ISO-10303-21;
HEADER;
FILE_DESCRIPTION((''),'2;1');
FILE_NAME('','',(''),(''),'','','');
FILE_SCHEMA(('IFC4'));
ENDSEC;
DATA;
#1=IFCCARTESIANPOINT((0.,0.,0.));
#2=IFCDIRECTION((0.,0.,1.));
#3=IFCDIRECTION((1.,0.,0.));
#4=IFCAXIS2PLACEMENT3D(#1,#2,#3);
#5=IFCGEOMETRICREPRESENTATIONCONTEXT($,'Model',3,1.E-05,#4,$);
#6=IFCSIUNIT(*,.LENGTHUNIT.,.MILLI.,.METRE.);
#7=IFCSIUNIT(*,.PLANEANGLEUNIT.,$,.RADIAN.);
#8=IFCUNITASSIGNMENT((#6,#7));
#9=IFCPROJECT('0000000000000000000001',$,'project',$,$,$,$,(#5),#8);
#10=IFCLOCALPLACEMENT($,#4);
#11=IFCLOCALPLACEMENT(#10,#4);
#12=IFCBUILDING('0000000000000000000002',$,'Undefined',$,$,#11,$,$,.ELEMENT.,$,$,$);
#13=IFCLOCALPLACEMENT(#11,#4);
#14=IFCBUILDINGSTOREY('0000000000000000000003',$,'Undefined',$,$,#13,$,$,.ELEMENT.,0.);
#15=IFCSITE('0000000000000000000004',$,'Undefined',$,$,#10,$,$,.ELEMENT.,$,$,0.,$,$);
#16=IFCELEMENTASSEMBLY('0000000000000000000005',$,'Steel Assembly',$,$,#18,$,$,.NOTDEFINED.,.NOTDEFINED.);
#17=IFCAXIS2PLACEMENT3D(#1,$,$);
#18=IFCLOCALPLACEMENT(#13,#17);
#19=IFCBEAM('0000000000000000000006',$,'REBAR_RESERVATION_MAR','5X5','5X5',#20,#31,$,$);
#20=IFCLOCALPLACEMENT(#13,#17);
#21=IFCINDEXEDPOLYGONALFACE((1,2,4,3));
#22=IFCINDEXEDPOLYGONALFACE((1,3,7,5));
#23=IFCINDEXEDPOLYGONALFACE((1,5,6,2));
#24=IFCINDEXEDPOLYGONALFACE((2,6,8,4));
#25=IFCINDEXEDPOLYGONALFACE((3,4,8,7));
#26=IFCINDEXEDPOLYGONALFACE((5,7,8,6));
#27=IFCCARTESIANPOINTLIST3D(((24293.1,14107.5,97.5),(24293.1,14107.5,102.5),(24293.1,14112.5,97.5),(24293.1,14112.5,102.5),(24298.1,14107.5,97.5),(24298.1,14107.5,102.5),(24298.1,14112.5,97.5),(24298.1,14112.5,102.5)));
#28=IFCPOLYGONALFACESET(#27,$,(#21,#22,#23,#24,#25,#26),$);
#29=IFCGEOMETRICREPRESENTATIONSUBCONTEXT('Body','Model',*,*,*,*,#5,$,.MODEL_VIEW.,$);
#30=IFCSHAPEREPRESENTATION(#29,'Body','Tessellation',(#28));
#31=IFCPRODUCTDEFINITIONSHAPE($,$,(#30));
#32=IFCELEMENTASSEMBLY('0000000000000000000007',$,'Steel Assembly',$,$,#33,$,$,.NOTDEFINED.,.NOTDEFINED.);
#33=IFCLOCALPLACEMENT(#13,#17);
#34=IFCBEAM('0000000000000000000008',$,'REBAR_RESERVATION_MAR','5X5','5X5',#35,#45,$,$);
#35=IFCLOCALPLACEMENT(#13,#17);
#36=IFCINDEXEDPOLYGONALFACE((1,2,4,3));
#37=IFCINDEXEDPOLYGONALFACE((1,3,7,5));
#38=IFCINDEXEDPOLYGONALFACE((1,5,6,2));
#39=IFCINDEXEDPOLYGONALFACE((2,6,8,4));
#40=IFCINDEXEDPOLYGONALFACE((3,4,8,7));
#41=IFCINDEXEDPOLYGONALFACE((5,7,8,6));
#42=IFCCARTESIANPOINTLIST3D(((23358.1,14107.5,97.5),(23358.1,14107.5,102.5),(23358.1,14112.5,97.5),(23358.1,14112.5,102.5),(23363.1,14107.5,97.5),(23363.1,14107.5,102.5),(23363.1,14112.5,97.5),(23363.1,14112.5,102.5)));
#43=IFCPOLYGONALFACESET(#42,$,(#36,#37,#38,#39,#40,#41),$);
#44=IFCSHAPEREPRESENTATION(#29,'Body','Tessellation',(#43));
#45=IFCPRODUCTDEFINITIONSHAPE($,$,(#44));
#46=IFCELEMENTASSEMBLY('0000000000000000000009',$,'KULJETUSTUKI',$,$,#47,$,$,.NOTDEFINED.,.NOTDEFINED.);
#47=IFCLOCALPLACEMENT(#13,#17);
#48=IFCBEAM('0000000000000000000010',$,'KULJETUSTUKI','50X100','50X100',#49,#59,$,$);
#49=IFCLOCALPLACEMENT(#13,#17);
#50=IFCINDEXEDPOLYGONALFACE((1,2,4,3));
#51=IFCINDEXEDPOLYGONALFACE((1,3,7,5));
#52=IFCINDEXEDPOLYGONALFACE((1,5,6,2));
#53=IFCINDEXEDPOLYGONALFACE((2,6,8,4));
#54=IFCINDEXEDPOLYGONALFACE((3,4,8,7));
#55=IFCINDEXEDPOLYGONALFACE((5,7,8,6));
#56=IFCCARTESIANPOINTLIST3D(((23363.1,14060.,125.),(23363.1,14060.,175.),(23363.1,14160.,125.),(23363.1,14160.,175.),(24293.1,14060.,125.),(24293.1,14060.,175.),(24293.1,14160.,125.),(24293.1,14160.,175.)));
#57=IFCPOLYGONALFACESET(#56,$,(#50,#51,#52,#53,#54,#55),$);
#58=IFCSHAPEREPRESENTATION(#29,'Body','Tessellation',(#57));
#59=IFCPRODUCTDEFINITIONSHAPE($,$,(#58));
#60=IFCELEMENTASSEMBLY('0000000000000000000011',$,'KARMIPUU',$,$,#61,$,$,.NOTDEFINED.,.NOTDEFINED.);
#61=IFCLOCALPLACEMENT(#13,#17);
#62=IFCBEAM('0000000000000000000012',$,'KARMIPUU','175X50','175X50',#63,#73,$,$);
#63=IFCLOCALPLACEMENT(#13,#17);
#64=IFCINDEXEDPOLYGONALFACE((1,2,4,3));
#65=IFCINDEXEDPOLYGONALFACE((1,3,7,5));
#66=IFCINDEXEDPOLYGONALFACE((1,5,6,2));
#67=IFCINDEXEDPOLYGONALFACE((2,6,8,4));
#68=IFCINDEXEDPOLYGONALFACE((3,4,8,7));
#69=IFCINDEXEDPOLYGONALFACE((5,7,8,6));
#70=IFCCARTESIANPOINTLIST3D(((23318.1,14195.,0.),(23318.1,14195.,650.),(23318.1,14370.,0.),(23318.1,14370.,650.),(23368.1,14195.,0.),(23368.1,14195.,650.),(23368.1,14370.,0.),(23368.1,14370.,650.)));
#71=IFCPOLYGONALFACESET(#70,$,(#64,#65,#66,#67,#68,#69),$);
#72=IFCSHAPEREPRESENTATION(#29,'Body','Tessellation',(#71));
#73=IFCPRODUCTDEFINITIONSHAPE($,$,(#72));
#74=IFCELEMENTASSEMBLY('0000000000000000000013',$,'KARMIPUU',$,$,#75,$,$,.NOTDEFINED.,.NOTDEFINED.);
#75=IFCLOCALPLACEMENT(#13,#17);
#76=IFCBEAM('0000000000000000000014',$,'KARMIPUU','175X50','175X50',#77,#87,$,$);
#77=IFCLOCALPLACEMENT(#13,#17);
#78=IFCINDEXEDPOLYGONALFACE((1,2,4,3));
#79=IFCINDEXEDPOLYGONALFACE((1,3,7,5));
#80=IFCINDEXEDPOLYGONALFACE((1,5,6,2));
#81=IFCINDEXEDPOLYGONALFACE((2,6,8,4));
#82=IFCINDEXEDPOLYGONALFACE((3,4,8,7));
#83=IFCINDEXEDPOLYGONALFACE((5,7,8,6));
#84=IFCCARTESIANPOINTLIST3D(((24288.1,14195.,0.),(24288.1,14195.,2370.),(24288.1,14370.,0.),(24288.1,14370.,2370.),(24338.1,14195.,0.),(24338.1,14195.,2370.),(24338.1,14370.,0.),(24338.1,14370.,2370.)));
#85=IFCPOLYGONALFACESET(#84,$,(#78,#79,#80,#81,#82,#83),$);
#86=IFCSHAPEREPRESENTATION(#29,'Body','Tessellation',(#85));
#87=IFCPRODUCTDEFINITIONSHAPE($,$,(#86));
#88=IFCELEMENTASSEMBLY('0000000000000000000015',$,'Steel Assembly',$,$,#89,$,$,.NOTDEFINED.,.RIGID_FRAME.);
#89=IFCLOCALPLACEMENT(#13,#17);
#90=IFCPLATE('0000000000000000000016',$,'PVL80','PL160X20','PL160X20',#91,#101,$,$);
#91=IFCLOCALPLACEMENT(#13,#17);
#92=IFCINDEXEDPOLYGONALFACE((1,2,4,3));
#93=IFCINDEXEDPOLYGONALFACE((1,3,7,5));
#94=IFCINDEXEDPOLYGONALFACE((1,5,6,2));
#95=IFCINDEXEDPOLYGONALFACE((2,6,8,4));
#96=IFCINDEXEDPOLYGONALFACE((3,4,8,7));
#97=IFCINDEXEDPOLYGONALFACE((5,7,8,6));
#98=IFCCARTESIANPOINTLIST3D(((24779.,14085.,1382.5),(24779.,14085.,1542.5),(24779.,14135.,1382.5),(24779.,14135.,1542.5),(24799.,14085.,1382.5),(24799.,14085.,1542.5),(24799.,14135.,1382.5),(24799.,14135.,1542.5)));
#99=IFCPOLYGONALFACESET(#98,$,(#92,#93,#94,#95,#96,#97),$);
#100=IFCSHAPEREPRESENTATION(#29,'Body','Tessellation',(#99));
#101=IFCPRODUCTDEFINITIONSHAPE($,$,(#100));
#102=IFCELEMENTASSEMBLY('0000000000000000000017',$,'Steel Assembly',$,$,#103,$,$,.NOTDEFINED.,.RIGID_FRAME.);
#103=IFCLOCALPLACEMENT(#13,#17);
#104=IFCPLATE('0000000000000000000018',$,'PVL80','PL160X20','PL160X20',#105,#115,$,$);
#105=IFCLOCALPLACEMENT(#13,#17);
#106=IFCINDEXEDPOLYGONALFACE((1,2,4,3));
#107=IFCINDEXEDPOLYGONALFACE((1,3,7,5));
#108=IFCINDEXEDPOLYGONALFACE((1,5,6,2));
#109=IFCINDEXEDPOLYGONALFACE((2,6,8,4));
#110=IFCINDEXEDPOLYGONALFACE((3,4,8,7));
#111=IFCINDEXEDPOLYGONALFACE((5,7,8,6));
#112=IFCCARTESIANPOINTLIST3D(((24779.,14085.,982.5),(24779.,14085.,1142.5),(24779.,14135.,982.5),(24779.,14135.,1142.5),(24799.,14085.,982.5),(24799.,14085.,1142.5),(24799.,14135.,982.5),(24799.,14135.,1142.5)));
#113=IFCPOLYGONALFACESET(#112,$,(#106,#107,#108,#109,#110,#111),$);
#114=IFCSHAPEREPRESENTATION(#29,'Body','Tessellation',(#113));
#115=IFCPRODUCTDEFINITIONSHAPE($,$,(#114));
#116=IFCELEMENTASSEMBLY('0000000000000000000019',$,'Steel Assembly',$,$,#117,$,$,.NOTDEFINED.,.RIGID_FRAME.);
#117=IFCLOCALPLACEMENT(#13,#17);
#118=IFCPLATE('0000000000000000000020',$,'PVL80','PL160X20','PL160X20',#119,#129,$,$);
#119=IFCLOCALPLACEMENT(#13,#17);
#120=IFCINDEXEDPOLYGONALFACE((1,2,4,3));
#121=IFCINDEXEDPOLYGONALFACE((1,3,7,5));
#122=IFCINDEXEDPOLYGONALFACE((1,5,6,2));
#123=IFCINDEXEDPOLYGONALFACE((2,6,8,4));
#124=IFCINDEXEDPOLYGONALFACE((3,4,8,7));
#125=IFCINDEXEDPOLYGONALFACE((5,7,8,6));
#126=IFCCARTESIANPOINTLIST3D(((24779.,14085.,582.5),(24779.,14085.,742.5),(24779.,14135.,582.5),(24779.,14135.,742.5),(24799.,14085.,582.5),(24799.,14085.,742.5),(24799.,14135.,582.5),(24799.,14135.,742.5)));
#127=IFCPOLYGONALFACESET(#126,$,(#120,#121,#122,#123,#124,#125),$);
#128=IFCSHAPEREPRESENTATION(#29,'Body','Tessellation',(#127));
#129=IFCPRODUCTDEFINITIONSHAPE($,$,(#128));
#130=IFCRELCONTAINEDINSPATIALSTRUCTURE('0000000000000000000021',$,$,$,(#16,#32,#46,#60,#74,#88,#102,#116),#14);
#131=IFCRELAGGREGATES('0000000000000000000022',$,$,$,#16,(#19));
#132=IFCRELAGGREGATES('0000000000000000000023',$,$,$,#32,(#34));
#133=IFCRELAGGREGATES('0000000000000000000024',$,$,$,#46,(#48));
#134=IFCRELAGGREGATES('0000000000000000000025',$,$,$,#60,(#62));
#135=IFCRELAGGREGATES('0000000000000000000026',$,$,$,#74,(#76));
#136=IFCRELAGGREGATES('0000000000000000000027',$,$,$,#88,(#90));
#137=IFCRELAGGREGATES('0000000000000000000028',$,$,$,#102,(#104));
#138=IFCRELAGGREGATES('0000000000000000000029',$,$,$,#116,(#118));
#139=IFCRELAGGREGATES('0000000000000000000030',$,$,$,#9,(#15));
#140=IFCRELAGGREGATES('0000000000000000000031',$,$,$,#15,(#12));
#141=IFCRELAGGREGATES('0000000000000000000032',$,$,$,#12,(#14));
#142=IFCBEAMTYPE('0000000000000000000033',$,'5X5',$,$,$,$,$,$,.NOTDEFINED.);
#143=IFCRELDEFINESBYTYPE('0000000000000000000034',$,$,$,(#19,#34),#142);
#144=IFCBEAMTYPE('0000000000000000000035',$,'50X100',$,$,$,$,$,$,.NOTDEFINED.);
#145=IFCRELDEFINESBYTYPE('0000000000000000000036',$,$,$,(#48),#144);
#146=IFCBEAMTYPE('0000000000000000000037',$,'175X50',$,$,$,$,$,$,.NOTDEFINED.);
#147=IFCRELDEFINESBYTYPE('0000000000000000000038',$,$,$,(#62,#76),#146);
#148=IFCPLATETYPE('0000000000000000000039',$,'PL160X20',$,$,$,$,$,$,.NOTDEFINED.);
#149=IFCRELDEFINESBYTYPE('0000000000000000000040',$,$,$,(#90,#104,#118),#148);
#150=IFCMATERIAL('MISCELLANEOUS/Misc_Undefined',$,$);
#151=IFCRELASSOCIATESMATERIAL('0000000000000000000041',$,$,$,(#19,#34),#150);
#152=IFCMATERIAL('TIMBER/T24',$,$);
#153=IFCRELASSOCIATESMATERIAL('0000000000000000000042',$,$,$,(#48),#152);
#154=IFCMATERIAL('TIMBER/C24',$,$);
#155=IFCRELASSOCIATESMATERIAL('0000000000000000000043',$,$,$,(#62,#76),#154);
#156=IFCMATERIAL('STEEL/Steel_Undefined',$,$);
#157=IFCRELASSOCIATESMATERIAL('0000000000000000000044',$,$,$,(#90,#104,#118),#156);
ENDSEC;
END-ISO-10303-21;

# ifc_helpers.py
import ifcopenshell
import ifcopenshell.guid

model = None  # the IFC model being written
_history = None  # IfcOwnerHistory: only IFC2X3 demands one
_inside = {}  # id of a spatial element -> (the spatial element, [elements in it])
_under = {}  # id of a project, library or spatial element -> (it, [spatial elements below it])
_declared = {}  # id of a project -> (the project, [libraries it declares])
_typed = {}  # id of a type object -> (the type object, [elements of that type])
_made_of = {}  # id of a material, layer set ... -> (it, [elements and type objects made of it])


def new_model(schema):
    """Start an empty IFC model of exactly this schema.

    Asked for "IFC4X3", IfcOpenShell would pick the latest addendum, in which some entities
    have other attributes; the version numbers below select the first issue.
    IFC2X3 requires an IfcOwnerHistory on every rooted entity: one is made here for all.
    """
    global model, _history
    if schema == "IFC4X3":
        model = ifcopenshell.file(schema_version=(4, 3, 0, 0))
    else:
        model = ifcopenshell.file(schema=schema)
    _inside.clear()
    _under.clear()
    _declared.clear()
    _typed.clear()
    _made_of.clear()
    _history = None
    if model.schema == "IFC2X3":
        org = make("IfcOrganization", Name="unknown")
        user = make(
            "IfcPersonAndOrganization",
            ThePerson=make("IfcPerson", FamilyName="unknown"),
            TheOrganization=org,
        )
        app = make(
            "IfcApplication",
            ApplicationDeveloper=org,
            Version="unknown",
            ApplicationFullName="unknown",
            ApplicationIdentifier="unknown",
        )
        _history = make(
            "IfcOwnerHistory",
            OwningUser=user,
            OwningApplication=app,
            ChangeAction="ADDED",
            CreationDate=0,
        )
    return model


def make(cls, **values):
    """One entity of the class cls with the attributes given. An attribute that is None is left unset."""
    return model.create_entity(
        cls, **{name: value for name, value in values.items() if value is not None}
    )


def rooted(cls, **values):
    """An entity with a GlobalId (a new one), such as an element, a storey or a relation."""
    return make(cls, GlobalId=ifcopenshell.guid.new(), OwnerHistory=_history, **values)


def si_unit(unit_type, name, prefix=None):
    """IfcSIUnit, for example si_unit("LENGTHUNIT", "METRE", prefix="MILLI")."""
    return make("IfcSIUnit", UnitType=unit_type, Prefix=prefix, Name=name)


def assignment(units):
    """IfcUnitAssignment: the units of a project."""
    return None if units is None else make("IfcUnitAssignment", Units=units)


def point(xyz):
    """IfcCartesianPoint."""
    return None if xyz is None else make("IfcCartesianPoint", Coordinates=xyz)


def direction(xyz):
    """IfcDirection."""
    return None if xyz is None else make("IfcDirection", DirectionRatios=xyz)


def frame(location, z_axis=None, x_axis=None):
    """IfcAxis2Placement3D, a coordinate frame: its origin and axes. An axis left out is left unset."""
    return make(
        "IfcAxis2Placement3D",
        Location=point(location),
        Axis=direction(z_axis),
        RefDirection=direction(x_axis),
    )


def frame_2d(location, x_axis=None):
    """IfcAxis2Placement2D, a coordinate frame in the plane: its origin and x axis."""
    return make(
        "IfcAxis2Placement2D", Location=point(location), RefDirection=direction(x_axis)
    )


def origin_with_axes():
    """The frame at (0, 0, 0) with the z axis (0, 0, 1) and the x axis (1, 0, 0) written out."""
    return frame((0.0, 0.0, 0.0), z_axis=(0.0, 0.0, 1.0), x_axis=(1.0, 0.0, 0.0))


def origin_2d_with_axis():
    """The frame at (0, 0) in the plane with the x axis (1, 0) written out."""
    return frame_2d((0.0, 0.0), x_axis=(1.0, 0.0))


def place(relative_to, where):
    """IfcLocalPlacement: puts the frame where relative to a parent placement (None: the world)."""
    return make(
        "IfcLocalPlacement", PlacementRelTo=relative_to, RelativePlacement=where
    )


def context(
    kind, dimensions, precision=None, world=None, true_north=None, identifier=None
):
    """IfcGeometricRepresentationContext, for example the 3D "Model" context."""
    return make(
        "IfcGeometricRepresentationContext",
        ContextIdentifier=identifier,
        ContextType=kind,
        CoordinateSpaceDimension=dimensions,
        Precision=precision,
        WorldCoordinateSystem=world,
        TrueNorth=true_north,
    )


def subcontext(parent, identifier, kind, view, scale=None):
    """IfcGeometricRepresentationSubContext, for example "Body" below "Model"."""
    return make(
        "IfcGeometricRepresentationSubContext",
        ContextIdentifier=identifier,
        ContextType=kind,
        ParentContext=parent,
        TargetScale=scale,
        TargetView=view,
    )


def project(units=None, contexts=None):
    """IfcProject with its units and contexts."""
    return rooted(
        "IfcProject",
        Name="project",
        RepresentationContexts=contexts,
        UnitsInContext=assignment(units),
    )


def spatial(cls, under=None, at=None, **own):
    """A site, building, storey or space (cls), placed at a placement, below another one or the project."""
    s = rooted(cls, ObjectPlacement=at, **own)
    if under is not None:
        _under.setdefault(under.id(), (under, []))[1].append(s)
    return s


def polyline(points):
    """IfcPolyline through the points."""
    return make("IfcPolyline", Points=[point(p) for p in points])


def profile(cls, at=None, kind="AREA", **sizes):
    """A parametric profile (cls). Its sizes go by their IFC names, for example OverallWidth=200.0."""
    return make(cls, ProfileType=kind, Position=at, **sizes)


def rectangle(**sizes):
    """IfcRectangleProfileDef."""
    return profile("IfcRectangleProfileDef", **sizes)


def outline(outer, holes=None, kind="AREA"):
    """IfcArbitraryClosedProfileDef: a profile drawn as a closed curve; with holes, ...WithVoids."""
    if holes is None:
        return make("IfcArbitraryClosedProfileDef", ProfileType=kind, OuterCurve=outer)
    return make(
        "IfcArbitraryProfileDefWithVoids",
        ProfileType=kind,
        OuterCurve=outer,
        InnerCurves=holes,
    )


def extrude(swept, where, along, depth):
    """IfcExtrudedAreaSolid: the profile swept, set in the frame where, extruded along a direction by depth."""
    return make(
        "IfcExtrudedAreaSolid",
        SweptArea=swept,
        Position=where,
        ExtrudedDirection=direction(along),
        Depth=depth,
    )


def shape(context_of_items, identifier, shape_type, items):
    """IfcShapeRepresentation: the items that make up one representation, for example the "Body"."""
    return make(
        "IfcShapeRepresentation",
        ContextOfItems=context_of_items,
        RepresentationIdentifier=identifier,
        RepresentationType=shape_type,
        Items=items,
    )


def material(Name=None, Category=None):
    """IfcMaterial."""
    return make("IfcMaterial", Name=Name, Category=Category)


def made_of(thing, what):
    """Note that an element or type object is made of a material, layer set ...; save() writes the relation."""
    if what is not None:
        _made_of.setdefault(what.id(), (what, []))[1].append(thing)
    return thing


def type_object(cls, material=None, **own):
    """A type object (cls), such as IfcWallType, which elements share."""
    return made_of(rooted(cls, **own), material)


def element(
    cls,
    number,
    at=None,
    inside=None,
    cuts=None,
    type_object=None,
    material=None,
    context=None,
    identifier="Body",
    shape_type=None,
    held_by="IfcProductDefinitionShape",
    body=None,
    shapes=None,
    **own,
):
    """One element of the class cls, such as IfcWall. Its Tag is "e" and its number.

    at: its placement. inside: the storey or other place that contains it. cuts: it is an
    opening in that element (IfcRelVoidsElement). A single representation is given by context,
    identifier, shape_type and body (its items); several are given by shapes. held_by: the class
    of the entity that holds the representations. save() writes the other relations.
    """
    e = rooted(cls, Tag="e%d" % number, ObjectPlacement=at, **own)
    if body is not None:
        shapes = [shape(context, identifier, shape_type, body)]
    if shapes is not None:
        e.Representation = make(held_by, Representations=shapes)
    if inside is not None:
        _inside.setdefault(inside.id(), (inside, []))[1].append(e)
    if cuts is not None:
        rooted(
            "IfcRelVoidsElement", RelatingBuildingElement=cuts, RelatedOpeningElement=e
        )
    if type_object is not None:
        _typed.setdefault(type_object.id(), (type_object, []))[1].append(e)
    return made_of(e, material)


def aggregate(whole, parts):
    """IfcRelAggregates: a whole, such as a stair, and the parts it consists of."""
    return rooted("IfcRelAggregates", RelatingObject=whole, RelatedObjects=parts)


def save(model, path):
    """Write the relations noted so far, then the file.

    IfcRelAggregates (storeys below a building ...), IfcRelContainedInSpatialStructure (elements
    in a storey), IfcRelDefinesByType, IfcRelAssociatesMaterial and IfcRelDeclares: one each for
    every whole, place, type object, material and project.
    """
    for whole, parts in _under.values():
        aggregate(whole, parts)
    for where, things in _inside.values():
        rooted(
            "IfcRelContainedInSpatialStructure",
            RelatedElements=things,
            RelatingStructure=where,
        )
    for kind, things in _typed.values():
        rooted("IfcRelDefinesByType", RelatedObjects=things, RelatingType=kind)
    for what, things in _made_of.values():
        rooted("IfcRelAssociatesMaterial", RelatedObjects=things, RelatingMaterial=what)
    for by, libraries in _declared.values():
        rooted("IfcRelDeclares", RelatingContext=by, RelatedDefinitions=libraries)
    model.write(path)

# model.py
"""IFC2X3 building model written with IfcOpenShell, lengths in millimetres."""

from ifc_helpers import new_model, si_unit, frame, origin_with_axes, origin_2d_with_axis, place, context, subcontext, project, spatial, polyline, rectangle, outline, extrude, material, type_object, element, aggregate, save


model = new_model("IFC2X3")

# Units and contexts
model_context = context("Model", 3, precision=1e-05, world=origin_with_axes())
body_context = subcontext(model_context, "Body", "Model", "MODEL_VIEW")
ifc_project = project(units=[si_unit("LENGTHUNIT", "METRE", prefix="MILLI"), si_unit("PLANEANGLEUNIT", "RADIAN")], contexts=[model_context])

# Site, building, storey
site_placement = place(None, origin_with_axes())
site = spatial("IfcSite", under=ifc_project, at=site_placement, Name="Undefined", CompositionType="ELEMENT", RefElevation=0.0)
building_placement = place(site_placement, origin_with_axes())
building = spatial("IfcBuilding", under=site, at=building_placement, Name="Undefined", CompositionType="ELEMENT")
storey_placement = place(building_placement, origin_with_axes())
storey = spatial("IfcBuildingStorey", under=building, at=storey_placement, Name="Undefined", CompositionType="ELEMENT", Elevation=0.0)

# Element assemblies, beams
assembly_1_placement = place(storey_placement, origin_with_axes())
assembly_1 = element("IfcElementAssembly", 1, at=assembly_1_placement, inside=storey, Name="Steel Assembly", AssemblyPlace="NOTDEFINED", PredefinedType="NOTDEFINED")
ifc_material_1 = material(Name="MISCELLANEOUS/Misc_Undefined")
beam_type_1 = type_object("IfcBeamType", Name="5X5", PredefinedType="NOTDEFINED")
beam_1_placement = place(assembly_1_placement, frame((24293.1, 14110.0, 100.0), z_axis=(0.0, 0.0, 1.0), x_axis=(1.0, 0.0, 0.0)))
beam_1 = element("IfcBeam", 2, at=beam_1_placement, type_object=beam_type_1, material=ifc_material_1, Name="REBAR_RESERVATION_MAR", Description="5X5", ObjectType="5X5", context=body_context, shape_type="SweptSolid", body=[
    extrude(rectangle(XDim=5.0, YDim=5.0, at=origin_2d_with_axis()), frame((5.0, 0.0, 0.0), z_axis=(-1.0, 0.0, 0.0), x_axis=(0.0, -1.0, 0.0)), (0.0, 0.0, 1.0), 5.0),
])
aggregate(assembly_1, [beam_1])
assembly_2_placement = place(storey_placement, origin_with_axes())
assembly_2 = element("IfcElementAssembly", 3, at=assembly_2_placement, inside=storey, Name="Steel Assembly", AssemblyPlace="NOTDEFINED", PredefinedType="NOTDEFINED")
beam_2_placement = place(assembly_2_placement, frame((23363.1, 14110.0, 100.0), z_axis=(0.0, 0.0, 1.0), x_axis=(-1.0, 0.0, 0.0)))
beam_2 = element("IfcBeam", 4, at=beam_2_placement, type_object=beam_type_1, material=ifc_material_1, Name="REBAR_RESERVATION_MAR", Description="5X5", ObjectType="5X5", context=body_context, shape_type="SweptSolid", body=[
    extrude(rectangle(XDim=5.0, YDim=5.0, at=origin_2d_with_axis()), frame((5.0, 0.0, 0.0), z_axis=(-1.0, 0.0, 0.0), x_axis=(0.0, -1.0, 0.0)), (0.0, 0.0, 1.0), 5.0),
])
aggregate(assembly_2, [beam_2])
assembly_3_placement = place(storey_placement, origin_with_axes())
assembly_3 = element("IfcElementAssembly", 5, at=assembly_3_placement, inside=storey, Name="KULJETUSTUKI", AssemblyPlace="NOTDEFINED", PredefinedType="NOTDEFINED")
ifc_material_2 = material(Name="TIMBER/T24")
beam_type_2 = type_object("IfcBeamType", Name="50X100", PredefinedType="NOTDEFINED")
beam_3_placement = place(assembly_3_placement, frame((23363.1, 14110.0, 150.0), z_axis=(0.0, 0.0, 1.0), x_axis=(1.0, 0.0, 0.0)))
beam_3 = element("IfcBeam", 6, at=beam_3_placement, type_object=beam_type_2, material=ifc_material_2, Name="KULJETUSTUKI", Description="50X100", ObjectType="50X100", context=body_context, shape_type="SweptSolid", body=[
    extrude(rectangle(XDim=100.0, YDim=50.0, at=origin_2d_with_axis()), frame((930.0, 0.0, 0.0), z_axis=(-1.0, 0.0, 0.0), x_axis=(0.0, -1.0, 0.0)), (0.0, 0.0, 1.0), 930.0),
])
aggregate(assembly_3, [beam_3])
assembly_4_placement = place(storey_placement, origin_with_axes())
assembly_4 = element("IfcElementAssembly", 7, at=assembly_4_placement, inside=storey, Name="KARMIPUU", AssemblyPlace="NOTDEFINED", PredefinedType="NOTDEFINED")
ifc_material_3 = material(Name="TIMBER/C24")
beam_type_3 = type_object("IfcBeamType", Name="175X50", PredefinedType="NOTDEFINED")
beam_4_placement = place(assembly_4_placement, frame((23343.1, 14282.5, 650.0), z_axis=(0.0, -1.0, 0.0), x_axis=(0.0, 0.0, -1.0)))
beam_4 = element("IfcBeam", 8, at=beam_4_placement, type_object=beam_type_3, material=ifc_material_3, Name="KARMIPUU", Description="175X50", ObjectType="175X50", context=body_context, shape_type="SweptSolid", body=[
    extrude(rectangle(XDim=50.0, YDim=175.0, at=origin_2d_with_axis()), frame((650.0, 0.0, 0.0), z_axis=(-1.0, 0.0, 0.0), x_axis=(0.0, -1.0, 0.0)), (0.0, 0.0, 1.0), 650.0),
])
aggregate(assembly_4, [beam_4])
assembly_5_placement = place(storey_placement, origin_with_axes())
assembly_5 = element("IfcElementAssembly", 9, at=assembly_5_placement, inside=storey, Name="KARMIPUU", AssemblyPlace="NOTDEFINED", PredefinedType="NOTDEFINED")
beam_5_placement = place(assembly_5_placement, frame((24313.1, 14282.5, 0.0), z_axis=(0.0, -1.0, 0.0), x_axis=(0.0, 0.0, 1.0)))
beam_5 = element("IfcBeam", 10, at=beam_5_placement, type_object=beam_type_3, material=ifc_material_3, Name="KARMIPUU", Description="175X50", ObjectType="175X50", context=body_context, shape_type="SweptSolid", body=[
    extrude(rectangle(XDim=50.0, YDim=175.0, at=origin_2d_with_axis()), frame((2370.0, 0.0, 0.0), z_axis=(-1.0, 0.0, 0.0), x_axis=(0.0, -1.0, 0.0)), (0.0, 0.0, 1.0), 2370.0),
])
aggregate(assembly_5, [beam_5])

# Element assemblies, plates
assembly_6_placement = place(storey_placement, origin_with_axes())
assembly_6 = element("IfcElementAssembly", 11, at=assembly_6_placement, inside=storey, Name="Steel Assembly", AssemblyPlace="NOTDEFINED", PredefinedType="RIGID_FRAME")
ifc_material_4 = material(Name="STEEL/Steel_Undefined")
plate_type = type_object("IfcPlateType", Name="PL160X20", PredefinedType="NOTDEFINED")
plate_1_placement = place(assembly_6_placement, frame((24799.0, 14135.0, 1462.5), z_axis=(0.0, 0.0, -1.0), x_axis=(0.0, -1.0, 0.0)))
plate_1 = element("IfcPlate", 12, at=plate_1_placement, type_object=plate_type, material=ifc_material_4, Name="PVL80", Description="PL160X20", ObjectType="PL160X20", context=body_context, shape_type="SweptSolid", body=[
    extrude(outline(polyline([(0.0, 0.0), (50.0, 0.0), (50.0, 20.0), (0.0, 20.0), (0.0, 0.0)])), frame((0.0, 0.0, -80.0), z_axis=(0.0, 0.0, 1.0), x_axis=(1.0, 0.0, 0.0)), (0.0, 0.0, 1.0), 160.0),
])
assembly_7_placement = place(storey_placement, origin_with_axes())
assembly_7 = element("IfcElementAssembly", 13, at=assembly_7_placement, inside=storey, Name="Steel Assembly", AssemblyPlace="NOTDEFINED", PredefinedType="RIGID_FRAME")
plate_2_placement = place(assembly_7_placement, frame((24799.0, 14135.0, 1062.5), z_axis=(0.0, 0.0, -1.0), x_axis=(0.0, -1.0, 0.0)))
plate_2 = element("IfcPlate", 14, at=plate_2_placement, type_object=plate_type, material=ifc_material_4, Name="PVL80", Description="PL160X20", ObjectType="PL160X20", context=body_context, shape_type="SweptSolid", body=[
    extrude(outline(polyline([(0.0, 0.0), (50.0, 0.0), (50.0, 20.0), (0.0, 20.0), (0.0, 0.0)])), frame((0.0, 0.0, -80.0), z_axis=(0.0, 0.0, 1.0), x_axis=(1.0, 0.0, 0.0)), (0.0, 0.0, 1.0), 160.0),
])
assembly_8_placement = place(storey_placement, origin_with_axes())
assembly_8 = element("IfcElementAssembly", 15, at=assembly_8_placement, inside=storey, Name="Steel Assembly", AssemblyPlace="NOTDEFINED", PredefinedType="RIGID_FRAME")
plate_3_placement = place(assembly_8_placement, frame((24799.0, 14135.0, 662.5), z_axis=(0.0, 0.0, -1.0), x_axis=(0.0, -1.0, 0.0)))
plate_3 = element("IfcPlate", 16, at=plate_3_placement, type_object=plate_type, material=ifc_material_4, Name="PVL80", Description="PL160X20", ObjectType="PL160X20", context=body_context, shape_type="SweptSolid", body=[
    extrude(outline(polyline([(0.0, 0.0), (50.0, 0.0), (50.0, 20.0), (0.0, 20.0), (0.0, 0.0)])), frame((0.0, 0.0, -80.0), z_axis=(0.0, 0.0, 1.0), x_axis=(1.0, 0.0, 0.0)), (0.0, 0.0, 1.0), 160.0),
])

aggregate(assembly_6, [plate_1])
aggregate(assembly_7, [plate_2])
aggregate(assembly_8, [plate_3])

save(model, "model.ifc")
